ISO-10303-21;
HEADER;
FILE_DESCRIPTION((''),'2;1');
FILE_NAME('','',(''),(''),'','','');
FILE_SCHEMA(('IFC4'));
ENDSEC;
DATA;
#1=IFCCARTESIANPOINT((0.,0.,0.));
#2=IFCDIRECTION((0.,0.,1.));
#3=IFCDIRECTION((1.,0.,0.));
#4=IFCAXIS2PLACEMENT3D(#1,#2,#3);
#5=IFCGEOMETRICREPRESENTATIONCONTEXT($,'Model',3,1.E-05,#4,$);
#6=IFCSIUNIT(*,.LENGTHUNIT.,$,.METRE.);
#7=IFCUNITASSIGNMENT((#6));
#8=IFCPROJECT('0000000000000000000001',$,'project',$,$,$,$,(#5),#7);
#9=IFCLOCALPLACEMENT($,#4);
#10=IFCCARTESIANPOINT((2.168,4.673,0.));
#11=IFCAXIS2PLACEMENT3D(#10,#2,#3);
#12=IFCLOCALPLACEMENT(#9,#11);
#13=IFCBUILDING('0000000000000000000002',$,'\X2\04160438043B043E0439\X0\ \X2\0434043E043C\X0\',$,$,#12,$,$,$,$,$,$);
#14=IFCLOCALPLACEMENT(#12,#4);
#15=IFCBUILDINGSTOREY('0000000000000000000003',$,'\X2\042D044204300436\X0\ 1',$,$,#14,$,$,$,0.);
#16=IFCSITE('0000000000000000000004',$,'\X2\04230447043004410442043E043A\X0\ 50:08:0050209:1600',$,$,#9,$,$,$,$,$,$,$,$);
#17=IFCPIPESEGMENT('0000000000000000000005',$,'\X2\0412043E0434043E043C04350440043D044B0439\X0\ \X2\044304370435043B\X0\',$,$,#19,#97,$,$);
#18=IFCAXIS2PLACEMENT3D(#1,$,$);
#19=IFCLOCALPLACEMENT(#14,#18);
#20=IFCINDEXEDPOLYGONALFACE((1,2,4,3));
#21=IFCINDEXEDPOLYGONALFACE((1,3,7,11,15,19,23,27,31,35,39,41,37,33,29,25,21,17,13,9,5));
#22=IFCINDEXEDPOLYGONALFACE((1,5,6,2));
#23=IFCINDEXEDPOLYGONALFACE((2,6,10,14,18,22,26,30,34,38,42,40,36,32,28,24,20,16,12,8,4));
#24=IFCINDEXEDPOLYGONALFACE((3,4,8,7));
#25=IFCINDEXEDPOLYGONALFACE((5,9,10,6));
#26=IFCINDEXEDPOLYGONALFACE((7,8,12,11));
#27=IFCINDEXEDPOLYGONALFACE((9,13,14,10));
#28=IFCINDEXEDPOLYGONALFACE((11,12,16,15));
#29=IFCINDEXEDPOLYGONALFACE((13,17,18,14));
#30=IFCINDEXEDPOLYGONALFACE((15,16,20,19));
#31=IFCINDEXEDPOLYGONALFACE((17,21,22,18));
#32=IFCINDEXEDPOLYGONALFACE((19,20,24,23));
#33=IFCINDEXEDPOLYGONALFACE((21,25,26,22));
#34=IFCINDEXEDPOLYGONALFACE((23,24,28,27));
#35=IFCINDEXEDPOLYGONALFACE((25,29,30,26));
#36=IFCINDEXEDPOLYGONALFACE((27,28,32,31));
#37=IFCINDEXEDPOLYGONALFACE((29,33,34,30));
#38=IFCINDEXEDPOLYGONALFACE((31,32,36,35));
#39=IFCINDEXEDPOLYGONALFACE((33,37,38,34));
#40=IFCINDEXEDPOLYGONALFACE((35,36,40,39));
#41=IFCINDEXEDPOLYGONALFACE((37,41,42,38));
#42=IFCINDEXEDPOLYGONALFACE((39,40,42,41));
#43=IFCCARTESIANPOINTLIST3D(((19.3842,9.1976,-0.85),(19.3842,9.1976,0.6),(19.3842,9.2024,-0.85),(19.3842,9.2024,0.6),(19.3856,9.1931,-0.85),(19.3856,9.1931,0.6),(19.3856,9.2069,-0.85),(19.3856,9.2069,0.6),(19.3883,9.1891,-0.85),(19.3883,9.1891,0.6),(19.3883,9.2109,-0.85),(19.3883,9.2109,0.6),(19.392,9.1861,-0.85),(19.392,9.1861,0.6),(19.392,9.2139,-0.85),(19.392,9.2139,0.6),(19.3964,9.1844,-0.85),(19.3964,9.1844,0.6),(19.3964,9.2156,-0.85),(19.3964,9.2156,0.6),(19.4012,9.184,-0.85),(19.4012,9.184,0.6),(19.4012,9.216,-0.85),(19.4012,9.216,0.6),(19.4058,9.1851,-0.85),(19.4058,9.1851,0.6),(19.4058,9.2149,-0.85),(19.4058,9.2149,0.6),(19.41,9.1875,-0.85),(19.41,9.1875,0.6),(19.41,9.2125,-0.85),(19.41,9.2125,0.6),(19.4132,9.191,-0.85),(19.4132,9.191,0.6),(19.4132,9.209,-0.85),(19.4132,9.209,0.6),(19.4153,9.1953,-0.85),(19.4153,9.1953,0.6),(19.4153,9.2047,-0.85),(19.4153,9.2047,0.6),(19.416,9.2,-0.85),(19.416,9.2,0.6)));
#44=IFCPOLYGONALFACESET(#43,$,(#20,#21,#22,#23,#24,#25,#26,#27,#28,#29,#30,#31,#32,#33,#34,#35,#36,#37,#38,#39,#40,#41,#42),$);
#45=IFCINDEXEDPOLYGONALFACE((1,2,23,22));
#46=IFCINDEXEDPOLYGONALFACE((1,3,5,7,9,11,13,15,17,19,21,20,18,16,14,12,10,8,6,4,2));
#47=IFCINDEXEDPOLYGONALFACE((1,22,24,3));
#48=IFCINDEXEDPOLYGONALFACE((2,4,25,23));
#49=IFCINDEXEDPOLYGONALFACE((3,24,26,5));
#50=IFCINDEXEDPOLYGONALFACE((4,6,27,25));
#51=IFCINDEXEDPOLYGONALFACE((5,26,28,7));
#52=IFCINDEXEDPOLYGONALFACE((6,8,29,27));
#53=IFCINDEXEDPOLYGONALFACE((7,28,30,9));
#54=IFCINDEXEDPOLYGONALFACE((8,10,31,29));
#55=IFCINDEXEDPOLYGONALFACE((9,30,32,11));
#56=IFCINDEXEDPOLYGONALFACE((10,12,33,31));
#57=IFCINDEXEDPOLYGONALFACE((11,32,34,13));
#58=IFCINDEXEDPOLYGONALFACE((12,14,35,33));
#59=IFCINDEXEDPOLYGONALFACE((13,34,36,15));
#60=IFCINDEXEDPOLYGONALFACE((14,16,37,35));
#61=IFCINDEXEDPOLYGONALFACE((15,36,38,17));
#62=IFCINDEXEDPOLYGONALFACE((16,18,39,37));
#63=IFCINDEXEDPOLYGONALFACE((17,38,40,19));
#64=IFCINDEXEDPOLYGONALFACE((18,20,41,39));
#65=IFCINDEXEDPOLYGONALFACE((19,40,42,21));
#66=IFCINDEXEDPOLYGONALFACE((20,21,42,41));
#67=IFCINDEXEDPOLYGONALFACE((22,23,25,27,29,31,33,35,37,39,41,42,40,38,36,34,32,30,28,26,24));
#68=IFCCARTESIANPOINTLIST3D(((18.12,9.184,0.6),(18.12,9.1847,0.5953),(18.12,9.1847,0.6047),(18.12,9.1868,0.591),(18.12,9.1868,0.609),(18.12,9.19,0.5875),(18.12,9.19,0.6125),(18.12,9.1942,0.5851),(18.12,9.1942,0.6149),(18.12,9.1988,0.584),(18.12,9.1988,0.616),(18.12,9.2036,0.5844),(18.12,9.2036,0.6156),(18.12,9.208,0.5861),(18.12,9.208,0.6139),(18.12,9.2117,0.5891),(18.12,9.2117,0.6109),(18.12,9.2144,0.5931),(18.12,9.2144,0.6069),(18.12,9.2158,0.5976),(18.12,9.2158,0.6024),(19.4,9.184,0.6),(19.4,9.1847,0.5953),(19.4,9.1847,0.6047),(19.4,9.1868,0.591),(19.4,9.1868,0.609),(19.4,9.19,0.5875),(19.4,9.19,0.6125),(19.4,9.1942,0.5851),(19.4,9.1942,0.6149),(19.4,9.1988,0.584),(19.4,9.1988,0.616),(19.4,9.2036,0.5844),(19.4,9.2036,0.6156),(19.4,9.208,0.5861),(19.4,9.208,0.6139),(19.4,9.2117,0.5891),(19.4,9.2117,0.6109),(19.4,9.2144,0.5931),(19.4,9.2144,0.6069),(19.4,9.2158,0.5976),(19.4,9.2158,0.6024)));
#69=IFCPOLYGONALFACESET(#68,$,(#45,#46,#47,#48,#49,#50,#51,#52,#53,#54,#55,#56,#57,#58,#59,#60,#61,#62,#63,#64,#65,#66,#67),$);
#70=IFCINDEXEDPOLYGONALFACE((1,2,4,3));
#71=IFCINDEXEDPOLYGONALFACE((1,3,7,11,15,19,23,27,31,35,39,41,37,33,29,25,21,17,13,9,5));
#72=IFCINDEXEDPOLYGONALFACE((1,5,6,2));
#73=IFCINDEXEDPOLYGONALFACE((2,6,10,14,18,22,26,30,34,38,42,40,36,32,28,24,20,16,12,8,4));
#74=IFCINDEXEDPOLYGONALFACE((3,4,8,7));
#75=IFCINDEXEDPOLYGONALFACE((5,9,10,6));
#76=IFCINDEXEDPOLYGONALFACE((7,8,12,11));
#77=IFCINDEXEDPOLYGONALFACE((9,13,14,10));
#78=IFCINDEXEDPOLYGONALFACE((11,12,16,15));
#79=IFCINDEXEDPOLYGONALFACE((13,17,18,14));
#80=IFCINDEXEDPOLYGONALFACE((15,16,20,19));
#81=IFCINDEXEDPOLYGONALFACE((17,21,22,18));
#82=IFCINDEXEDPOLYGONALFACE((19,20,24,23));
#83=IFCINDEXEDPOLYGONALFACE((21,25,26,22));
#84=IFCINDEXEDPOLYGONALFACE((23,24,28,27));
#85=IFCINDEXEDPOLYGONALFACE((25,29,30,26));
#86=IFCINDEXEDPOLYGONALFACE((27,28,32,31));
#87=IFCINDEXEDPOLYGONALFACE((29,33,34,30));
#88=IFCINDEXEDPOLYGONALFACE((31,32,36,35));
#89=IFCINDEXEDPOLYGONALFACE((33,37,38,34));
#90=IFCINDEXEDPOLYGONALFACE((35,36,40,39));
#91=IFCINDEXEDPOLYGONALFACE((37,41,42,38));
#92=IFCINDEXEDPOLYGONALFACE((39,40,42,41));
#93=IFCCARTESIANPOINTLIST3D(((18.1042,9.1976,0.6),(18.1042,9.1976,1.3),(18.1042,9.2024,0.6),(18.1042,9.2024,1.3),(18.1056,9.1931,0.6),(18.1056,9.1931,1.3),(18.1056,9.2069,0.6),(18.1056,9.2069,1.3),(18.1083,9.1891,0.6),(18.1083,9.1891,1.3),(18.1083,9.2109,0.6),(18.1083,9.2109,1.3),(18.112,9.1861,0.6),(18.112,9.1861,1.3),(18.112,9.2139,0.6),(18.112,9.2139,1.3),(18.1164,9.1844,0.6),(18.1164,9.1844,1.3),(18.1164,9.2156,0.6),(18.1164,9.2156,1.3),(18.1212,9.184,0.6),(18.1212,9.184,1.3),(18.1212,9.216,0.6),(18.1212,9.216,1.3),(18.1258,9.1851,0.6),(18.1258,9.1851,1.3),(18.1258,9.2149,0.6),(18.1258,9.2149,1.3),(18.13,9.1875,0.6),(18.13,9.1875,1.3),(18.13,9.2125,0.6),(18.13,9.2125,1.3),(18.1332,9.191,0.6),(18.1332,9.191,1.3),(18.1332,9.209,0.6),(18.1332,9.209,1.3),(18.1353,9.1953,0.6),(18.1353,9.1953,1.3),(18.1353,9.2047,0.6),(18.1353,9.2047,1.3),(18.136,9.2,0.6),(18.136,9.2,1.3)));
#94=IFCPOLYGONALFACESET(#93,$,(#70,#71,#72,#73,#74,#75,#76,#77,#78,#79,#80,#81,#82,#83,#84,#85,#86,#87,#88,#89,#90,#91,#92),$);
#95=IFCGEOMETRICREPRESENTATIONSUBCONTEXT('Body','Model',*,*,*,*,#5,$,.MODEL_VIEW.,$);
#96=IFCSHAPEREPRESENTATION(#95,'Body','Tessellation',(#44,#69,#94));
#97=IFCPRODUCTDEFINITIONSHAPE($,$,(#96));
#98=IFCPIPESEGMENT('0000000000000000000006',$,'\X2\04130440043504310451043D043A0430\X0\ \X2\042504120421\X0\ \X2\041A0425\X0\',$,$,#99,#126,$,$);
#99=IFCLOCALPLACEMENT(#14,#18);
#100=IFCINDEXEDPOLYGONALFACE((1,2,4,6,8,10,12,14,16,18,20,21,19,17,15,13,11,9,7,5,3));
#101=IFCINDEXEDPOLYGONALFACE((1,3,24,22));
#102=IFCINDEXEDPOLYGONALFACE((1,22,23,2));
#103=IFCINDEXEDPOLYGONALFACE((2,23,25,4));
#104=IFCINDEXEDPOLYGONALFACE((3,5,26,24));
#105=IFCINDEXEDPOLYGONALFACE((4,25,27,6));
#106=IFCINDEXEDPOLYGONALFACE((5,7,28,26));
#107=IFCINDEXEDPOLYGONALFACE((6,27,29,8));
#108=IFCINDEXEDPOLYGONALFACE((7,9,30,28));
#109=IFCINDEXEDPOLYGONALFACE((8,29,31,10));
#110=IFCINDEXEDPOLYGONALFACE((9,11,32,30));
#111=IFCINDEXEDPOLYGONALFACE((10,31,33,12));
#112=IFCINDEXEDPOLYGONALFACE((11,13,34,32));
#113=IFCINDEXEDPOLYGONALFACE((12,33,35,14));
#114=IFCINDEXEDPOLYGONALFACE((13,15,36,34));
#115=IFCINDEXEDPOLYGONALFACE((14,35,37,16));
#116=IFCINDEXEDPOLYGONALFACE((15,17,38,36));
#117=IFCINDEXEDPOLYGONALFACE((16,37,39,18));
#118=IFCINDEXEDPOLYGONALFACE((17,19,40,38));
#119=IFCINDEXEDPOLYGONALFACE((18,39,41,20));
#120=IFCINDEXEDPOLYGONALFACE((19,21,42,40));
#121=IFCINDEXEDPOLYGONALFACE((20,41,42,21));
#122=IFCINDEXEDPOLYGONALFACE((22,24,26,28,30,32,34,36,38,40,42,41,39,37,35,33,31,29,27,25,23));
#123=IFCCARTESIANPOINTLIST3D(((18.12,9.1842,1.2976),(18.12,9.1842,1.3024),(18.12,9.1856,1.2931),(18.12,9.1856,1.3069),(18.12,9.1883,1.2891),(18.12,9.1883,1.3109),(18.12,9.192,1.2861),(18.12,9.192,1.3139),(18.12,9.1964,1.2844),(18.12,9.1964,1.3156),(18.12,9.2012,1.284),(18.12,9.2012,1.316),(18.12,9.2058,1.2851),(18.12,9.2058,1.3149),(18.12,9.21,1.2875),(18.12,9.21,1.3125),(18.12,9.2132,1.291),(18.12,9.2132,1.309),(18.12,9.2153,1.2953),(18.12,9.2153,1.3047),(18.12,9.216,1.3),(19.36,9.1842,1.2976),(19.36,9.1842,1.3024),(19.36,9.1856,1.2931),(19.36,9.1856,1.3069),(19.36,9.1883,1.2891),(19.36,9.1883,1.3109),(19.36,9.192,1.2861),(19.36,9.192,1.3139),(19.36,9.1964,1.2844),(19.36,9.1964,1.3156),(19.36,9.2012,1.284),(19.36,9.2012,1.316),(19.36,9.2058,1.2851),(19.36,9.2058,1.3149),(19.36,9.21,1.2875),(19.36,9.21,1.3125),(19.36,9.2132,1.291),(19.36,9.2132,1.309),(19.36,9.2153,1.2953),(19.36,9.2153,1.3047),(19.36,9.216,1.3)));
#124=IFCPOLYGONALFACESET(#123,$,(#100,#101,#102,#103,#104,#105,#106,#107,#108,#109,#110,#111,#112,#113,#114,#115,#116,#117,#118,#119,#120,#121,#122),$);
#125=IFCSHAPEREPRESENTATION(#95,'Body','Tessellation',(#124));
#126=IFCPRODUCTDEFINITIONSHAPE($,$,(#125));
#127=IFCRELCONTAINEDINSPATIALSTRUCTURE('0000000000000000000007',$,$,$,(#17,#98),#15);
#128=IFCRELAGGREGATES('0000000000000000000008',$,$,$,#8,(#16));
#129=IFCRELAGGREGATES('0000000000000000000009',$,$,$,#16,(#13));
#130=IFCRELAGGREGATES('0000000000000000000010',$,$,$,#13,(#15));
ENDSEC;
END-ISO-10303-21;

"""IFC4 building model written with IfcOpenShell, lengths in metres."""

from ifc_helpers import new_model, si_unit, frame, origin_with_axes, origin_2d, place, context, subcontext, project, spatial, circle, extrude, element, save


model = new_model("IFC4")

# Units and contexts
model_context = context("Model", 3, precision=1e-05, world=origin_with_axes())
body_context = subcontext(model_context, "Body", "Model", "MODEL_VIEW")
ifc_project = project(units=[si_unit("LENGTHUNIT", "METRE")], contexts=[model_context])

# Site, building, storey
site_placement = place(None, origin_with_axes())
site = spatial("IfcSite", under=ifc_project, at=site_placement, Name="Участок 50:08:0050209:1600")
building_placement = place(site_placement, frame((2.168, 4.673, 0.0), z_axis=(0.0, 0.0, 1.0), x_axis=(1.0, 0.0, 0.0)))
building = spatial("IfcBuilding", under=site, at=building_placement, Name="Жилой дом")
storey_placement = place(building_placement, origin_with_axes())
storey = spatial("IfcBuildingStorey", under=building, at=storey_placement, Name="Этаж 1", Elevation=0.0)

# Pipe segments
pipe_segment_1_placement = place(storey_placement, origin_with_axes())
element("IfcPipeSegment", 1, at=pipe_segment_1_placement, inside=storey, Name="Водомерный узел", context=body_context, shape_type="SweptSolid", body=[
    extrude(circle(Radius=0.016, at=origin_2d()), frame((19.4, 9.2, -0.85), z_axis=(0.0, 0.0, 1.0), x_axis=(1.0, 0.0, 0.0)), (0.0, 0.0, 1.0), 1.45),
    extrude(circle(Radius=0.016, at=origin_2d()), frame((19.4, 9.2, 0.6), z_axis=(-1.0, 0.0, 0.0), x_axis=(0.0, -1.0, 0.0)), (0.0, 0.0, 1.0), 1.28),
    extrude(circle(Radius=0.016, at=origin_2d()), frame((18.12, 9.2, 0.6), z_axis=(0.0, 0.0, 1.0), x_axis=(1.0, 0.0, 0.0)), (0.0, 0.0, 1.0), 0.7),
])
pipe_segment_2_placement = place(storey_placement, origin_with_axes())
element("IfcPipeSegment", 2, at=pipe_segment_2_placement, inside=storey, Name="Гребёнка ХВС КХ", context=body_context, shape_type="SweptSolid", body=[
    extrude(circle(Radius=0.016, at=origin_2d()), frame((18.12, 9.2, 1.3), z_axis=(1.0, 0.0, 0.0), x_axis=(0.0, 1.0, 0.0)), (0.0, 0.0, 1.0), 1.24),
])

save(model, "model.ifc")
